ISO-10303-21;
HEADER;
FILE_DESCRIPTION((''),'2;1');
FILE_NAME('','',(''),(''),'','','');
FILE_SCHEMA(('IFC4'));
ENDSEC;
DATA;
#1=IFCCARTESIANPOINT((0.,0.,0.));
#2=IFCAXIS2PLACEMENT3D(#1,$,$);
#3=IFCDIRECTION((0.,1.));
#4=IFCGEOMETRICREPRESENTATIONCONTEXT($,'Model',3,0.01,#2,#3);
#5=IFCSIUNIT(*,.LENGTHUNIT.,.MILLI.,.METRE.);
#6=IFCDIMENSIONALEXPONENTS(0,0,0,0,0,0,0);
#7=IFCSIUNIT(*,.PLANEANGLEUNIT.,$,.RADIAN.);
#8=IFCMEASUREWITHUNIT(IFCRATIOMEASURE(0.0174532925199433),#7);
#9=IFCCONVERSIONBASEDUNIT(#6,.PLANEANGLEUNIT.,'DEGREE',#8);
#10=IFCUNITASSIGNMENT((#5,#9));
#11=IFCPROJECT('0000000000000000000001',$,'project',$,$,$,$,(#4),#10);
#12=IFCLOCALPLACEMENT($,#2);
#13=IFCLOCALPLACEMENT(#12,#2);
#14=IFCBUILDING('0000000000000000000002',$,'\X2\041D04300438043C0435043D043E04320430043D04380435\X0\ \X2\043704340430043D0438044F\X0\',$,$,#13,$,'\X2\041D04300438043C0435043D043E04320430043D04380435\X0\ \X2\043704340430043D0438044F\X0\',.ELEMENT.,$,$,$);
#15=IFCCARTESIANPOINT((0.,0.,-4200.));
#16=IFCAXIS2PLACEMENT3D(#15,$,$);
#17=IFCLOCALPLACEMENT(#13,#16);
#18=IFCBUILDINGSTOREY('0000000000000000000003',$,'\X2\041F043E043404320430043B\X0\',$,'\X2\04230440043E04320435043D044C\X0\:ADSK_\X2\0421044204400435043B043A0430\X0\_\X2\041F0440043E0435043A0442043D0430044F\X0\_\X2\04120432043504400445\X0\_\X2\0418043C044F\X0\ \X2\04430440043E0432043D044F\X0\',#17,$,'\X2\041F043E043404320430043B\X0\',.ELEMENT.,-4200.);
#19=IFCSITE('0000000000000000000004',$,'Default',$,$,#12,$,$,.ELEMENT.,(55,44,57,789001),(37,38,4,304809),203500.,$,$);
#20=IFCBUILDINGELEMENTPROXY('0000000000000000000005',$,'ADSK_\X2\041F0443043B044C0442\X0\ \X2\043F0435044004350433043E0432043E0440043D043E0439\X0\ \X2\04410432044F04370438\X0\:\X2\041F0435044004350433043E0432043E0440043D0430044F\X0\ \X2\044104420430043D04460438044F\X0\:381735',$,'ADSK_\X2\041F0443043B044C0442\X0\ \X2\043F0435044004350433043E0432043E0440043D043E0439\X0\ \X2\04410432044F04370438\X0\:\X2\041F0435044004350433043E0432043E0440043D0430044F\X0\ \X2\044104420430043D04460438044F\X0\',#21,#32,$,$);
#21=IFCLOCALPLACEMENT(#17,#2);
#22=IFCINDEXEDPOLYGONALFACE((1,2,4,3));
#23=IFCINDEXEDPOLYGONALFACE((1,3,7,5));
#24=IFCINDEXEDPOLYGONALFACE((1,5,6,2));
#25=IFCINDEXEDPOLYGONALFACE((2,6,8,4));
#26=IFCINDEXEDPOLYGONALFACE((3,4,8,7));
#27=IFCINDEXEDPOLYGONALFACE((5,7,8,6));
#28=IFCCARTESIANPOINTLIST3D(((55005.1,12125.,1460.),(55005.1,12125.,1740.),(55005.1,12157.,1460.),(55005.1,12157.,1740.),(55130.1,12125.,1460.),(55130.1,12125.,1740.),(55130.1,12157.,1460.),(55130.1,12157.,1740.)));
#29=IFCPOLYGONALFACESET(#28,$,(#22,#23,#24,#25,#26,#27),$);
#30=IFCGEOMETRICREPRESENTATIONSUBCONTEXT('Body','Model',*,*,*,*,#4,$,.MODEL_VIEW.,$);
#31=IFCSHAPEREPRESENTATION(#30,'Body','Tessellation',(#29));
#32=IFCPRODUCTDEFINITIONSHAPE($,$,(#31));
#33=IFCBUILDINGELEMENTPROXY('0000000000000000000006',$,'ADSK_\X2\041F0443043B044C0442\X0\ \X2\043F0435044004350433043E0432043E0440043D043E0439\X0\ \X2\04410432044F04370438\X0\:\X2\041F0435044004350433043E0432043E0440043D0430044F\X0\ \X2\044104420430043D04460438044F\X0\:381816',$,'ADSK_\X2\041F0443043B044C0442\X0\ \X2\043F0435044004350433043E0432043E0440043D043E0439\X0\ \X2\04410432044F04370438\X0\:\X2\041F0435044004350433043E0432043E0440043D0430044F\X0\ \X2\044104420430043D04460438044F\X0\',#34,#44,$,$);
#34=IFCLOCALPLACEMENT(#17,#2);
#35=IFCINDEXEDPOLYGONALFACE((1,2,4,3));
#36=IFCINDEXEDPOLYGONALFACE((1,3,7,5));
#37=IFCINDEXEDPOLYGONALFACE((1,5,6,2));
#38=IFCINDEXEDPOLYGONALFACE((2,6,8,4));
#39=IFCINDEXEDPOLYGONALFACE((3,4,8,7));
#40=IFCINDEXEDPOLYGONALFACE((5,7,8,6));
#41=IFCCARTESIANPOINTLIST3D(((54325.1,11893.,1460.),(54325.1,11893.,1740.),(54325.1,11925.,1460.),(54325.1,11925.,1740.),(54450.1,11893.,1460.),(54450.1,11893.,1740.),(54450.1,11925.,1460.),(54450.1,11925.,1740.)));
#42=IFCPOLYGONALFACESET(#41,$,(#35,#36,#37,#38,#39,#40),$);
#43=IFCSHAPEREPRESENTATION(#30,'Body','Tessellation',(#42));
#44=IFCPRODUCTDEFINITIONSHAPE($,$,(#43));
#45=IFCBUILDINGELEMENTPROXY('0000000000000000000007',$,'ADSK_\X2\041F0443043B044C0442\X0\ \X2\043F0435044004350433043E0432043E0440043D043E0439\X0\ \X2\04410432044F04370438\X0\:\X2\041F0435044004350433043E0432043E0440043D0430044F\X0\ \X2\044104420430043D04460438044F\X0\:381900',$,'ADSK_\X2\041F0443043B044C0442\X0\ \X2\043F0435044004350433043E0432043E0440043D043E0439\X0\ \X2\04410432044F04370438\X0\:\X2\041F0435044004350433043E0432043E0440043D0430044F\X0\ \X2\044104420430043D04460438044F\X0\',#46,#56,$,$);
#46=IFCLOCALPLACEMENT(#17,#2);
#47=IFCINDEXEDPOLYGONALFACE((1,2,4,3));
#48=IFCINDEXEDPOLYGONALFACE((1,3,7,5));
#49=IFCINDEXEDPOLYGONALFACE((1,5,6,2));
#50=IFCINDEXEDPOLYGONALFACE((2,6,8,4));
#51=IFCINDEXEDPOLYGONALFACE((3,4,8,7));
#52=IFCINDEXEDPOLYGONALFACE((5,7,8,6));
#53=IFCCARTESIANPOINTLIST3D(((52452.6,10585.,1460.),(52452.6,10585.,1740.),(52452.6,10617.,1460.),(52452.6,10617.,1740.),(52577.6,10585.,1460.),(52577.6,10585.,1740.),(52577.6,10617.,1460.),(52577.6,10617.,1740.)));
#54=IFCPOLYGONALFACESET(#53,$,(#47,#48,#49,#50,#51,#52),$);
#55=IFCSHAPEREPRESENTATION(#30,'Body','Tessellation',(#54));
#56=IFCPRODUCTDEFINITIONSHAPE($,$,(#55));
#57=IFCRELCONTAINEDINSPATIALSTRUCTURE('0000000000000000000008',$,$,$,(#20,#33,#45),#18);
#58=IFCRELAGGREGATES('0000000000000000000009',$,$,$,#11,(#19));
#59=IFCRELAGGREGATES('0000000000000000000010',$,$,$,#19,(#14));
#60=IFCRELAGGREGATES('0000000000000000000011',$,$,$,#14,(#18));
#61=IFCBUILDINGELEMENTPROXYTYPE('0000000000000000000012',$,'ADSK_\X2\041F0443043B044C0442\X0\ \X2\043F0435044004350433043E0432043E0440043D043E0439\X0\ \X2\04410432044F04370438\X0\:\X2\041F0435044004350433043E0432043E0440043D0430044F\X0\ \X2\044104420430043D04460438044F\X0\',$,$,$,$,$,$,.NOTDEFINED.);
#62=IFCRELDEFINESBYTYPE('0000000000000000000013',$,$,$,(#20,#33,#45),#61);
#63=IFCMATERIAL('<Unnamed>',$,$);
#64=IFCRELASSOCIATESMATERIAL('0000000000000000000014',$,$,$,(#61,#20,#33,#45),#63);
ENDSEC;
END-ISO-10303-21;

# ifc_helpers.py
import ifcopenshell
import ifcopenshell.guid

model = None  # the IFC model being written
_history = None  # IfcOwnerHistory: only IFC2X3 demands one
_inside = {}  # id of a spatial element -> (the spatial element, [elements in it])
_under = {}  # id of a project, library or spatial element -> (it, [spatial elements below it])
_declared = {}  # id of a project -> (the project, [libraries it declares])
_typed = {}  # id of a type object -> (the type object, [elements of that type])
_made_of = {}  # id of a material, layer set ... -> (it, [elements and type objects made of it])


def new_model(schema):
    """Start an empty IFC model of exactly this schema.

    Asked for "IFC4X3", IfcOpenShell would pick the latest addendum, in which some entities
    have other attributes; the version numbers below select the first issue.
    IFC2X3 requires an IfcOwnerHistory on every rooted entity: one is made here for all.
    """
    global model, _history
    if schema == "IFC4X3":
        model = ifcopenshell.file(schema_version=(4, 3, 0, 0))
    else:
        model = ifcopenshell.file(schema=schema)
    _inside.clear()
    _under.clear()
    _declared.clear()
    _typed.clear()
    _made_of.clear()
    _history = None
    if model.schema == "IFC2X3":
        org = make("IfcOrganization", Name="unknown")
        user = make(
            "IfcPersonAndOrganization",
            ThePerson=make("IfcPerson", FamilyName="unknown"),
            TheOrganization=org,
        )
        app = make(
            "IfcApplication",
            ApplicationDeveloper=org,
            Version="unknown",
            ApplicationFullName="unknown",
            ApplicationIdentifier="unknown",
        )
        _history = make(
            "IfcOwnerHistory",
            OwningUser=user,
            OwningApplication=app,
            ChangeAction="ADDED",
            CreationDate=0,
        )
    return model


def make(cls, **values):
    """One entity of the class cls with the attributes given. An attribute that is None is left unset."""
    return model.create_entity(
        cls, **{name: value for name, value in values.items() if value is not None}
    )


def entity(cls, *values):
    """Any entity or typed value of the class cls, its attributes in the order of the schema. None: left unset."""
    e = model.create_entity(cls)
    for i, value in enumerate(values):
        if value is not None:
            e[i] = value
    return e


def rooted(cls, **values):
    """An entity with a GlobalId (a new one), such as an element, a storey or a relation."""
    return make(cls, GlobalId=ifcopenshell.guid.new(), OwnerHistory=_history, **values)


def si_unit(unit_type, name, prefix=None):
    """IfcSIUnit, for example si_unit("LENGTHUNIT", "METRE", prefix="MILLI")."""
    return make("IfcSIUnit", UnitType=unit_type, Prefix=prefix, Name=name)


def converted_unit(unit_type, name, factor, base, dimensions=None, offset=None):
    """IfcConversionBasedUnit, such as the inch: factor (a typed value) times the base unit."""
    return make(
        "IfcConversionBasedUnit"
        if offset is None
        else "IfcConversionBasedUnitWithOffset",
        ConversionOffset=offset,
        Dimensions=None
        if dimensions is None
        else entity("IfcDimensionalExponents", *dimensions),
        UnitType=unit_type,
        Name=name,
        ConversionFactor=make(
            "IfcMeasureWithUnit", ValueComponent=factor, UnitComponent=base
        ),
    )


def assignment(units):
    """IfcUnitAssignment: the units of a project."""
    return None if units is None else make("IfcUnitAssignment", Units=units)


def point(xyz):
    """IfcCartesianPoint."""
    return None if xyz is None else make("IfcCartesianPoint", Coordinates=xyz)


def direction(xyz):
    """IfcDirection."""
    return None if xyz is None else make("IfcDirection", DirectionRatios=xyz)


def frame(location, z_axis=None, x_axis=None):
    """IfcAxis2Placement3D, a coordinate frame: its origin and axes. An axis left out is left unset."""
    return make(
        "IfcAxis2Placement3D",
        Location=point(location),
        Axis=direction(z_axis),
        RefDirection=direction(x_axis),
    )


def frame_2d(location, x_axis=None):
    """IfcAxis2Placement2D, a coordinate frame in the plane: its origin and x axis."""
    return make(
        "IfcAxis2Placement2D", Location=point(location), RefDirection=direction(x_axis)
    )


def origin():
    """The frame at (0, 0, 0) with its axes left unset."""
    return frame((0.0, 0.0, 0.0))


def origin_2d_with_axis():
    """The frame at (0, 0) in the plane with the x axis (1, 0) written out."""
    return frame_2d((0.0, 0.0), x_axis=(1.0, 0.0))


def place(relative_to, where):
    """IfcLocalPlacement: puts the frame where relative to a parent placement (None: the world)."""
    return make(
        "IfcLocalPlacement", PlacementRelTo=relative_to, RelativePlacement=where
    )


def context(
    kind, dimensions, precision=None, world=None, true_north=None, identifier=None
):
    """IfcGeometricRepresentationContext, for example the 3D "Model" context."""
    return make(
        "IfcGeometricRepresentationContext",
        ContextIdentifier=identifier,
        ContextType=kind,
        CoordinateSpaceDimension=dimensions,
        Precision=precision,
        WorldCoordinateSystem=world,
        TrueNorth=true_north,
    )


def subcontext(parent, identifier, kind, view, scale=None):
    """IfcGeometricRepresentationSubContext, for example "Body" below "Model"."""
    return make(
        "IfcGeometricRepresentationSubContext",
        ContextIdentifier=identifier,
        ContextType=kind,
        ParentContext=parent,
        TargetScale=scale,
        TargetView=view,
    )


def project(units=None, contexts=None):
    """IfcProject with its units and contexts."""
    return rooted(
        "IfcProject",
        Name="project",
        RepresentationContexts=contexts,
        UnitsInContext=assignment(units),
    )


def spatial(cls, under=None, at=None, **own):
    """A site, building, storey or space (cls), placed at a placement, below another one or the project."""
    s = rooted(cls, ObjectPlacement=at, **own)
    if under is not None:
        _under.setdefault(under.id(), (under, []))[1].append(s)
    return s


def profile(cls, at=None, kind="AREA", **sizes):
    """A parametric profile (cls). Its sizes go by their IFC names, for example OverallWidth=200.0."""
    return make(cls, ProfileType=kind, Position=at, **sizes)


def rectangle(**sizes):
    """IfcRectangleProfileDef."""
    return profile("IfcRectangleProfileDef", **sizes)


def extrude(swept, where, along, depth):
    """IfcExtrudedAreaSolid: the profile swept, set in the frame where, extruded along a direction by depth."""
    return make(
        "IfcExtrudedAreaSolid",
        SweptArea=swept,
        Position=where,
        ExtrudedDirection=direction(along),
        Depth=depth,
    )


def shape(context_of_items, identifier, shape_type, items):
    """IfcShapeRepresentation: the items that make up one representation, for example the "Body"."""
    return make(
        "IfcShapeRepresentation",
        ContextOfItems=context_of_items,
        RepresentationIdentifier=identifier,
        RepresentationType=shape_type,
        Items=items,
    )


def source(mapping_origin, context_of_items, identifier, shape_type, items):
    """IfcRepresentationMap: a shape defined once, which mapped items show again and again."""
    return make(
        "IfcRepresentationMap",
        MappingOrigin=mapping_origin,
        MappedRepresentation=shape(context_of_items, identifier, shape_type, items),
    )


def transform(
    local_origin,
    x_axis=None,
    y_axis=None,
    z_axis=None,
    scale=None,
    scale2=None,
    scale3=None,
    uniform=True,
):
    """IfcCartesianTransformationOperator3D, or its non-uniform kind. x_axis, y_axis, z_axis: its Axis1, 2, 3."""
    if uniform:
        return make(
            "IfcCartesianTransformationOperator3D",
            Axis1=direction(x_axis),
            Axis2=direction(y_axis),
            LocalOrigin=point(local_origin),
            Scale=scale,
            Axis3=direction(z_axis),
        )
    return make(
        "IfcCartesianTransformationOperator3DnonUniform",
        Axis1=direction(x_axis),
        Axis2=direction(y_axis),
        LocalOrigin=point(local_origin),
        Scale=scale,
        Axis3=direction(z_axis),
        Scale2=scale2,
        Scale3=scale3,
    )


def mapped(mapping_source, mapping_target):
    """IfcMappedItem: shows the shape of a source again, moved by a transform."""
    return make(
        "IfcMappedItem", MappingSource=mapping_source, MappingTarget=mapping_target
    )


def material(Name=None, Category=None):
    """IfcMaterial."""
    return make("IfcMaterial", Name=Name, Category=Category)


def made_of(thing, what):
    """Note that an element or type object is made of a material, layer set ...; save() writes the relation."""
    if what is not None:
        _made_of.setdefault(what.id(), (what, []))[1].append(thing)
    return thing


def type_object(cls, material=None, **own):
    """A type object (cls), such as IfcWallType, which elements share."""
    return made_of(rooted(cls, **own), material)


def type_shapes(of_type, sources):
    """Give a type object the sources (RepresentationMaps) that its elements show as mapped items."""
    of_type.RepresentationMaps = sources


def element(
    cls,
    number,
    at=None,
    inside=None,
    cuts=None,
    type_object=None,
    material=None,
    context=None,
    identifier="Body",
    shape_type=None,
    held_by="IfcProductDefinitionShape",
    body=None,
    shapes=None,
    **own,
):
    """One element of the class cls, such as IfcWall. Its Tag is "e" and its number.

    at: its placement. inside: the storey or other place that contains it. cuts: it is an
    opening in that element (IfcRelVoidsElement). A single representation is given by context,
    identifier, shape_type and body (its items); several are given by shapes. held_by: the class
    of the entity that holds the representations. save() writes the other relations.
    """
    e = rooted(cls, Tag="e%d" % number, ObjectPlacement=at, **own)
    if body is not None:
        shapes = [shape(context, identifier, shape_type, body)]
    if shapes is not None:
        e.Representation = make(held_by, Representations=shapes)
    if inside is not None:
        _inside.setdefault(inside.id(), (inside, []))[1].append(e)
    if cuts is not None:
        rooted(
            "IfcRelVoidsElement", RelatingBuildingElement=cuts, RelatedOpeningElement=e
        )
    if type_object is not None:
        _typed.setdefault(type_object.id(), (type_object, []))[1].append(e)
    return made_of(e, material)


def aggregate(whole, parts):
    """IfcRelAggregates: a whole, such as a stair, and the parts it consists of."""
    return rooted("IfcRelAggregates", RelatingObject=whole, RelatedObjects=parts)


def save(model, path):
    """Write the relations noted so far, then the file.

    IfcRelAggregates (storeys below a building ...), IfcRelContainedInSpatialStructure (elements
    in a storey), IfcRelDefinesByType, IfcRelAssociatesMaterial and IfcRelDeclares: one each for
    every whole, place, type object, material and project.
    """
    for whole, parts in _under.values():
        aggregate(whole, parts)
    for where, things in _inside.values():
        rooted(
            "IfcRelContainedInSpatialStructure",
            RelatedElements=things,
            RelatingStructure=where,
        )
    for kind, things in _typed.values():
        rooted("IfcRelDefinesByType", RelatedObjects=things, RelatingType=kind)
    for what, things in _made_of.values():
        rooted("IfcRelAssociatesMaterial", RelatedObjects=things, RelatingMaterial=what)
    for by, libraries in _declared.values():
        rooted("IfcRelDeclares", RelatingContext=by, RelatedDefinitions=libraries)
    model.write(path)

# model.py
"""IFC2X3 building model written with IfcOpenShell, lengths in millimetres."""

from ifc_helpers import new_model, entity, si_unit, converted_unit, direction, frame, origin, origin_2d_with_axis, place, context, subcontext, project, spatial, rectangle, extrude, source, transform, mapped, material, type_object, type_shapes, element, save


model = new_model("IFC2X3")

# Units and contexts
model_context = context("Model", 3, precision=0.01, world=origin(), true_north=direction((0.0, 1.0)))
body_context = subcontext(model_context, "Body", "Model", "MODEL_VIEW")
ifc_project = project(units=[si_unit("LENGTHUNIT", "METRE", prefix="MILLI"), converted_unit("PLANEANGLEUNIT", "DEGREE", entity("IfcRatioMeasure", 0.0174532925199433), si_unit("PLANEANGLEUNIT", "RADIAN"), dimensions=[0, 0, 0, 0, 0, 0, 0])], contexts=[model_context])

# Site, building, storey
site_placement = place(None, origin())
site = spatial("IfcSite", under=ifc_project, at=site_placement, Name="Default", CompositionType="ELEMENT", RefLatitude=(55, 44, 57, 789001), RefLongitude=(37, 38, 4, 304809), RefElevation=203500.0)
building_placement = place(site_placement, origin())
building = spatial("IfcBuilding", under=site, at=building_placement, Name="Наименование здания", LongName="Наименование здания", CompositionType="ELEMENT")
storey_placement = place(building_placement, frame((0.0, 0.0, -4200.0)))
storey = spatial("IfcBuildingStorey", under=building, at=storey_placement, Name="Подвал", ObjectType="Уровень:ADSK_Стрелка_Проектная_Вверх_Имя уровня", LongName="Подвал", CompositionType="ELEMENT", Elevation=-4200.0)

# Building element proxies
ifc_material = material(Name="<Unnamed>")
building_element_proxy_type = type_object("IfcBuildingElementProxyType", Name="ADSK_Пульт переговорной связи:Переговорная станция", PredefinedType="NOTDEFINED", material=ifc_material)
shared_shape = source(origin(), body_context, "Body", "SweptSolid", [
    extrude(rectangle(XDim=125.0, YDim=32.0, at=origin_2d_with_axis()), frame((0.0, 16.0, -140.0), z_axis=(0.0, 0.0, 1.0), x_axis=(-1.0, 0.0, 0.0)), (0.0, 0.0, 1.0), 280.0),
])
type_shapes(building_element_proxy_type, [shared_shape])
proxy_1_placement = place(storey_placement, frame((55067.6, 12157.0, 1600.0), z_axis=(0.0, 0.0, 1.0), x_axis=(-1.0, 0.0, 0.0)))
element("IfcBuildingElementProxy", 1, at=proxy_1_placement, inside=storey, type_object=building_element_proxy_type, material=ifc_material, Name="ADSK_Пульт переговорной связи:Переговорная станция:381735", ObjectType="ADSK_Пульт переговорной связи:Переговорная станция", context=body_context, shape_type="MappedRepresentation", body=[
    mapped(shared_shape, transform((0.0, 0.0, 0.0), scale=1.0)),
])
proxy_2_placement = place(storey_placement, frame((54387.6, 11893.0, 1600.0)))
element("IfcBuildingElementProxy", 2, at=proxy_2_placement, inside=storey, type_object=building_element_proxy_type, material=ifc_material, Name="ADSK_Пульт переговорной связи:Переговорная станция:381816", ObjectType="ADSK_Пульт переговорной связи:Переговорная станция", context=body_context, shape_type="MappedRepresentation", body=[
    mapped(shared_shape, transform((0.0, 0.0, 0.0), scale=1.0)),
])
proxy_3_placement = place(storey_placement, frame((52515.1, 10617.0, 1600.0), z_axis=(0.0, 0.0, 1.0), x_axis=(-1.0, 0.0, 0.0)))
element("IfcBuildingElementProxy", 3, at=proxy_3_placement, inside=storey, type_object=building_element_proxy_type, material=ifc_material, Name="ADSK_Пульт переговорной связи:Переговорная станция:381900", ObjectType="ADSK_Пульт переговорной связи:Переговорная станция", context=body_context, shape_type="MappedRepresentation", body=[
    mapped(shared_shape, transform((0.0, 0.0, 0.0), scale=1.0)),
])

save(model, "model.ifc")
